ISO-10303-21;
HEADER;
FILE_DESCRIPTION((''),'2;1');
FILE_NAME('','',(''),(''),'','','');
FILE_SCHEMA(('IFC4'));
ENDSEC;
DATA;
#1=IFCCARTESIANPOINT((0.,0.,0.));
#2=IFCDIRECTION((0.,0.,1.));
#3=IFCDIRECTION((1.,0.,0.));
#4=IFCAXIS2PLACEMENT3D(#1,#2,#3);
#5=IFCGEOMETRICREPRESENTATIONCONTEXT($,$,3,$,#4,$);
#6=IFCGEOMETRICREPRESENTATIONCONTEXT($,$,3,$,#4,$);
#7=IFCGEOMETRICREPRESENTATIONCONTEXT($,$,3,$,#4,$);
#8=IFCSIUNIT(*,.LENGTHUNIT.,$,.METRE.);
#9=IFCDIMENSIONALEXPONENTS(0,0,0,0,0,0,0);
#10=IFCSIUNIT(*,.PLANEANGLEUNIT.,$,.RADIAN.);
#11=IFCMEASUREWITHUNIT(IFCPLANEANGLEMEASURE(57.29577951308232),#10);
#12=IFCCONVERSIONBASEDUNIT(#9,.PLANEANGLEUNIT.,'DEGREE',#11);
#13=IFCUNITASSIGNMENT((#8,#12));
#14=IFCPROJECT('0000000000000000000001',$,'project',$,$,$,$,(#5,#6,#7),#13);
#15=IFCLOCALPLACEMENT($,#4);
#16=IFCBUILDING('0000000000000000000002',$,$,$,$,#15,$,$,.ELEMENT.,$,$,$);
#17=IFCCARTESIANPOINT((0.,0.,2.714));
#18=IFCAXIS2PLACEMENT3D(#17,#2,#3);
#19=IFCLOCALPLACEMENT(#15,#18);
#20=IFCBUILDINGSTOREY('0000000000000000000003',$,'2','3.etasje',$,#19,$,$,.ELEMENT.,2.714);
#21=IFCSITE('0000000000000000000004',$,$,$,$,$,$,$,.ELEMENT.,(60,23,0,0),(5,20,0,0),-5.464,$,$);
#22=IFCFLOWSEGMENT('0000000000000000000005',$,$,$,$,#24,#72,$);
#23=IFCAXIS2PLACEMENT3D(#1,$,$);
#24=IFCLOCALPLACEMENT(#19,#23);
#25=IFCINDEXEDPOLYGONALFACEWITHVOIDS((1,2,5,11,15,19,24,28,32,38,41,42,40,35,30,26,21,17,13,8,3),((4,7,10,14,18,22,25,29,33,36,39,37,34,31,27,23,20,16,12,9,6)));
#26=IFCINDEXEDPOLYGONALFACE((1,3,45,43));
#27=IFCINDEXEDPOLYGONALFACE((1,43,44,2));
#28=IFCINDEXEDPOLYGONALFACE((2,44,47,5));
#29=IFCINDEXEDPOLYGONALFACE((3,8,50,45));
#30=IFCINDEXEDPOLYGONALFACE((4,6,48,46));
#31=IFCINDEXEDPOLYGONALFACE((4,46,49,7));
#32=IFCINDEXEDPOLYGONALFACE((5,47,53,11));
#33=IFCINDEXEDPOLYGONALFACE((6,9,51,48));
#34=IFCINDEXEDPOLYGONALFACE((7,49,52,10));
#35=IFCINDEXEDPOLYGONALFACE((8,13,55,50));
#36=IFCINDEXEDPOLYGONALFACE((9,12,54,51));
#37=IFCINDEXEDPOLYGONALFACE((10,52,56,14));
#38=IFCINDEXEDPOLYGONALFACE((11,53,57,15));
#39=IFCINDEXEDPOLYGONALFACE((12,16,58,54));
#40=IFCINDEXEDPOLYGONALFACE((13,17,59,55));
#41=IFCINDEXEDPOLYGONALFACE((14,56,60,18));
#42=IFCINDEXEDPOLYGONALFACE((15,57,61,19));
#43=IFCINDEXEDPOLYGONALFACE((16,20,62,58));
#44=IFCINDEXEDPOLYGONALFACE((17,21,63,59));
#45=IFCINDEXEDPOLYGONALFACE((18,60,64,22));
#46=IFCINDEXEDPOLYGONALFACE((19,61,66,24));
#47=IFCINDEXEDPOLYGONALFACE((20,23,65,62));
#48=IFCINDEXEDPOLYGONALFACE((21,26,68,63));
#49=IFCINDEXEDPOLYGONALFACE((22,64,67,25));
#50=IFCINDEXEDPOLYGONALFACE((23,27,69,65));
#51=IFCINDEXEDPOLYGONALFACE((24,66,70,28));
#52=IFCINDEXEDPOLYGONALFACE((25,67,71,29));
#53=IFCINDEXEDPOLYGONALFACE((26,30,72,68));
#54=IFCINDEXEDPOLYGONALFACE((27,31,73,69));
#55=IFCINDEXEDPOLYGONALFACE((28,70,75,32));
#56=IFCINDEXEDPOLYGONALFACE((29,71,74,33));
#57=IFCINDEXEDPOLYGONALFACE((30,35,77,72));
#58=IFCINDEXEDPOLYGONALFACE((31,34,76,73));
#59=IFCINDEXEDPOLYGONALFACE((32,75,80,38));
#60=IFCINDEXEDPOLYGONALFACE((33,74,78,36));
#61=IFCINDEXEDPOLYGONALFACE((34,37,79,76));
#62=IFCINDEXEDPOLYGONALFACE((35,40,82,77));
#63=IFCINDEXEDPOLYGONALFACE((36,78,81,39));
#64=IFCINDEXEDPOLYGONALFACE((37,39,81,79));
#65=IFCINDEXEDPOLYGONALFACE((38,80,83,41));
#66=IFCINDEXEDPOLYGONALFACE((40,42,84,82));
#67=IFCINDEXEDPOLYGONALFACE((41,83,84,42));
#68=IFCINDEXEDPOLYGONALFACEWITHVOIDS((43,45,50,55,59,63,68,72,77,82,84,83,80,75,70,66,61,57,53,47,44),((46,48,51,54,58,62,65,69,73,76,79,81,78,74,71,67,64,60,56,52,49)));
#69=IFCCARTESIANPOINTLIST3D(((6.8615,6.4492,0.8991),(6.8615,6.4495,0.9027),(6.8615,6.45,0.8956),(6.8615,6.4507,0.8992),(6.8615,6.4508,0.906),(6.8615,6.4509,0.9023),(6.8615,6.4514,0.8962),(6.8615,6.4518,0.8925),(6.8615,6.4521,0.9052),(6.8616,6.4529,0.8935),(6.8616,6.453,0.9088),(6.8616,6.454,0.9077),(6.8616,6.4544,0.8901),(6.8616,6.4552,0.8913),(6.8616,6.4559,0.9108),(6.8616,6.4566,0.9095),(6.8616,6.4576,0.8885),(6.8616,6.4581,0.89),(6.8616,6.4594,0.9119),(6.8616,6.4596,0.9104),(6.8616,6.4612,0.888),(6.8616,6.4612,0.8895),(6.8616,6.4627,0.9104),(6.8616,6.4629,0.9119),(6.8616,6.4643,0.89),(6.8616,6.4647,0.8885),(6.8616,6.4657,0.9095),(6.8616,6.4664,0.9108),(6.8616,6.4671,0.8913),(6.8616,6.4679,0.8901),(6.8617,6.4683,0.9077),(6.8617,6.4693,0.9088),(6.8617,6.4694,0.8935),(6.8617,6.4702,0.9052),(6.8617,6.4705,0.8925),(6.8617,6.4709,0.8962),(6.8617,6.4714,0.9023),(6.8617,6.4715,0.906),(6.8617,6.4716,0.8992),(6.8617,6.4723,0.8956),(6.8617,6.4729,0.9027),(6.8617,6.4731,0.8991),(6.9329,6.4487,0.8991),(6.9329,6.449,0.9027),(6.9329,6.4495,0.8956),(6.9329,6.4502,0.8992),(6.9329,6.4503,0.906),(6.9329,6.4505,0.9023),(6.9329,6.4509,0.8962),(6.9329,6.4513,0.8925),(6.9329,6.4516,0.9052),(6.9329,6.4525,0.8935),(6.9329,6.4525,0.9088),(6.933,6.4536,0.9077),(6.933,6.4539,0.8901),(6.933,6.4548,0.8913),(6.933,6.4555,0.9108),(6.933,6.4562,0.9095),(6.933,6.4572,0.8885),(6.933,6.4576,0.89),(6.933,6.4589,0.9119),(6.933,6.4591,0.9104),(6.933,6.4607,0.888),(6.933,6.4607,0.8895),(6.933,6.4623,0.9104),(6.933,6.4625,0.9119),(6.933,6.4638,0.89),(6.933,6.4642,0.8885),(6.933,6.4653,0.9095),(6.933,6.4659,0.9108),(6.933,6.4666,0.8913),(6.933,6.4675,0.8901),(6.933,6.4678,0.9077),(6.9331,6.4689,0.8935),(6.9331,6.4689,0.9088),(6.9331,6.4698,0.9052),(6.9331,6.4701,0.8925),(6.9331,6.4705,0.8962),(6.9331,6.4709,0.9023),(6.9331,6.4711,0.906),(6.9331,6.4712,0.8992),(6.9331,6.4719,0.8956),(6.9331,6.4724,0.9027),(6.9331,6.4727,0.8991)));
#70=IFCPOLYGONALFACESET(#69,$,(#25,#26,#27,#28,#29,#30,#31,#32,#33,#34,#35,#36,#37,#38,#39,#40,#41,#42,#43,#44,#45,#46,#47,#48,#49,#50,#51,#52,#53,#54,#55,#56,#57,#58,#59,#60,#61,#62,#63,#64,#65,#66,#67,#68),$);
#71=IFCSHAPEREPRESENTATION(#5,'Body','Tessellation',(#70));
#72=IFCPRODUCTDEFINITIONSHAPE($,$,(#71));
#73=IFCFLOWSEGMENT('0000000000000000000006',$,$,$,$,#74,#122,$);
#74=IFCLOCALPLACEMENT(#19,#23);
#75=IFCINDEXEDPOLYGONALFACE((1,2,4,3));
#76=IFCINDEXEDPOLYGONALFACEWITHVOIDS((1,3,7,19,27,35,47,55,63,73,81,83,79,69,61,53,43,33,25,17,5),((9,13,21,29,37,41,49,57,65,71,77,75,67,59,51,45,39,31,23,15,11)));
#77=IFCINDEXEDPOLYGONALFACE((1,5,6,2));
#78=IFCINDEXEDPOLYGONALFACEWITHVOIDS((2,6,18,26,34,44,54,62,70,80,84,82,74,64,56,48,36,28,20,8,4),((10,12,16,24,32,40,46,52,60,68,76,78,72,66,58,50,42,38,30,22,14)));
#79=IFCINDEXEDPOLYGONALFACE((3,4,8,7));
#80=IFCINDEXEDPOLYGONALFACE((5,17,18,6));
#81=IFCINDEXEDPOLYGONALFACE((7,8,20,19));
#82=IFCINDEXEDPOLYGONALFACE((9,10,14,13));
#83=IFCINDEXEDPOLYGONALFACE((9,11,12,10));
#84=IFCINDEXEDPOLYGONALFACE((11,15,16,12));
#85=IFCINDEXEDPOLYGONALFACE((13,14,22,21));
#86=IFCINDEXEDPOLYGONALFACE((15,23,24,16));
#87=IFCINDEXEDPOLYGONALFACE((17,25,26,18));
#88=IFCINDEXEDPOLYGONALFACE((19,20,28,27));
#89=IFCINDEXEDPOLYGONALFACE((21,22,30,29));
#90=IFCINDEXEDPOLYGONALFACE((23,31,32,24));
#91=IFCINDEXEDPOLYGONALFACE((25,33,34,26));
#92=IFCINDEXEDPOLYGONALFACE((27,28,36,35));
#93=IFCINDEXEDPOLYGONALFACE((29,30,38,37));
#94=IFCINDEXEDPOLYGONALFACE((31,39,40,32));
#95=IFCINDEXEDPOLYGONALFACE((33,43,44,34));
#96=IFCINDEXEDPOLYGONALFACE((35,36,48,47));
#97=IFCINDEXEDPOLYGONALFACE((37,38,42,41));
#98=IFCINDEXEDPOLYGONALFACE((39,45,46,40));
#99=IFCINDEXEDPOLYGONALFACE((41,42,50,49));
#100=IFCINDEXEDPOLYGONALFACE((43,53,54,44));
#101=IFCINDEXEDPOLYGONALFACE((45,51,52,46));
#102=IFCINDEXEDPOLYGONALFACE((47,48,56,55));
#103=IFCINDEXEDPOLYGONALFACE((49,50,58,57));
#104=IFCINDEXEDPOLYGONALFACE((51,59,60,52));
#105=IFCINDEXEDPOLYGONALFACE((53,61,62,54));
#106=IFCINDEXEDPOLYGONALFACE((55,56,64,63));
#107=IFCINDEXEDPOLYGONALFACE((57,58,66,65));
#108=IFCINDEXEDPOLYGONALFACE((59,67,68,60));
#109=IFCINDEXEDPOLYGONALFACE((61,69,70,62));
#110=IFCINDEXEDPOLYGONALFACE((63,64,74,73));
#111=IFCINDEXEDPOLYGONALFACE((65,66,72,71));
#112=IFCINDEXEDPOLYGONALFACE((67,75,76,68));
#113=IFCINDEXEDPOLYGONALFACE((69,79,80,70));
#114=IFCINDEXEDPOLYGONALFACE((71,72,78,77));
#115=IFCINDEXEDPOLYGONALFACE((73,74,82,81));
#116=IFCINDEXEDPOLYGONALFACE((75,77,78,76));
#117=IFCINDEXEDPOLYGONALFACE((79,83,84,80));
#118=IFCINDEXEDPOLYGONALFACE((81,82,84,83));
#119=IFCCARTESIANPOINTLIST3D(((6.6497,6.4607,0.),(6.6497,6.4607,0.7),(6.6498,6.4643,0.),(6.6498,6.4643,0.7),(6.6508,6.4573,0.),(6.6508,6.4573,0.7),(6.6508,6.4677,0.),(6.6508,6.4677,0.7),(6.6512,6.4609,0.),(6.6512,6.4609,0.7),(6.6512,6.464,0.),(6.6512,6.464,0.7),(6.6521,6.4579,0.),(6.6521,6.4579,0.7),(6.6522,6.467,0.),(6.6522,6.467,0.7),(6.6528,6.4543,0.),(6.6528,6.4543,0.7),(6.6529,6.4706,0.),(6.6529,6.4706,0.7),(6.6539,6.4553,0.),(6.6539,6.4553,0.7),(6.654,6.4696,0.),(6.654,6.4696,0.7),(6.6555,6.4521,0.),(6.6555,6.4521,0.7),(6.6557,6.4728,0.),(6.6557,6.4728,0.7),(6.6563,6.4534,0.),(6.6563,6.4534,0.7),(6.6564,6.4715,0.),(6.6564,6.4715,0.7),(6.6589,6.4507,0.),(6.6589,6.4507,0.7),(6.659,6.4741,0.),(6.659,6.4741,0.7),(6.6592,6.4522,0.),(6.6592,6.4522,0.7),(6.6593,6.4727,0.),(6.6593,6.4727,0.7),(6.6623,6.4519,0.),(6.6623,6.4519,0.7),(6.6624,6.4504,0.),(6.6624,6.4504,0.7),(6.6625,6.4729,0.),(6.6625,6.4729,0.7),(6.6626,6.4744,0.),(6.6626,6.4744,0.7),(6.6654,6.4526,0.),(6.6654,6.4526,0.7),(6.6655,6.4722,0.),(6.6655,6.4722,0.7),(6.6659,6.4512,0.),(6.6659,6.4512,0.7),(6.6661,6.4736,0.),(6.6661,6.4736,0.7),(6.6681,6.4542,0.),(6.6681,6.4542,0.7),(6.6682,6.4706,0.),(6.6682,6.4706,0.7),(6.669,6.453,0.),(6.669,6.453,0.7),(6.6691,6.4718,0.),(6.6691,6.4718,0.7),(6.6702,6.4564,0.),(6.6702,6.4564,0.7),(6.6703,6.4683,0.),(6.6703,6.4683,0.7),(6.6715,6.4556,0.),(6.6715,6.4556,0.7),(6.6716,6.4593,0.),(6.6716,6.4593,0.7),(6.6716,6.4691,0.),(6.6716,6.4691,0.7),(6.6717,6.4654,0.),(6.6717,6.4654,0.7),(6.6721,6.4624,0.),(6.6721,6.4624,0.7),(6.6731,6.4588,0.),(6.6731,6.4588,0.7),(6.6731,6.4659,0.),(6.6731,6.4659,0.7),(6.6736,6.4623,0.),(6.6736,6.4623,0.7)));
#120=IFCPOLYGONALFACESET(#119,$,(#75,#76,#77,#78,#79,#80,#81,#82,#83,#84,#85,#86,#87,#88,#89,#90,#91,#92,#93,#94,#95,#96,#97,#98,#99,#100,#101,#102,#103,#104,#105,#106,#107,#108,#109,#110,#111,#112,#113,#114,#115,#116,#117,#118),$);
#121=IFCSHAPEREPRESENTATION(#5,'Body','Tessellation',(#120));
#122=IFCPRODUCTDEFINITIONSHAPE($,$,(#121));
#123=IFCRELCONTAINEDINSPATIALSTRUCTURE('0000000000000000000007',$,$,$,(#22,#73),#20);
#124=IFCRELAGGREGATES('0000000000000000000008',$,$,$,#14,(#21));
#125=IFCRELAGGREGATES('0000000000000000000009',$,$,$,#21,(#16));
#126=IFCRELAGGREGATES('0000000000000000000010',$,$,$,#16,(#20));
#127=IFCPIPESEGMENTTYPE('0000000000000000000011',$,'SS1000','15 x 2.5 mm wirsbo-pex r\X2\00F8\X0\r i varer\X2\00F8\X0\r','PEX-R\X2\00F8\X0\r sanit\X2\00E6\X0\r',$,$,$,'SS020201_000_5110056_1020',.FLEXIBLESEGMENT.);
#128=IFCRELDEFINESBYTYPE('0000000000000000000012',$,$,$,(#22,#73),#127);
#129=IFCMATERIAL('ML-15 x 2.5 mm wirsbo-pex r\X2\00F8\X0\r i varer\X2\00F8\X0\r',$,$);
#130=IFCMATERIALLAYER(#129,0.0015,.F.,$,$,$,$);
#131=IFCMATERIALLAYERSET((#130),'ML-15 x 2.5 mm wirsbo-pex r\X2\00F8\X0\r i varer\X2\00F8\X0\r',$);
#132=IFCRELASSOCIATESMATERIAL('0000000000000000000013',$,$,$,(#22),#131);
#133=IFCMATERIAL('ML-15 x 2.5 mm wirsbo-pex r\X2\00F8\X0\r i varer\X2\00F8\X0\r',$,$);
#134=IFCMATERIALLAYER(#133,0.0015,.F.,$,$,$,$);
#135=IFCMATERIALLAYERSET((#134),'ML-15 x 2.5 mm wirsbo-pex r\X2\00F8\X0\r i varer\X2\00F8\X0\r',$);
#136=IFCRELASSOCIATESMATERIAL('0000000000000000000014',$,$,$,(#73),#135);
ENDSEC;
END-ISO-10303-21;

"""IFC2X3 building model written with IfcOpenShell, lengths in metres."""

from ifc_helpers import new_model, entity, si_unit, converted_unit, frame, origin_with_axes, origin_2d_with_axis, place, context, project, spatial, hollow_circle, extrude, material, layer, layer_set, layer_usage, type_object, element, save


model = new_model("IFC2X3")

# Units and contexts
context_of_model_1 = context(None, 3, world=origin_with_axes())
context_of_model_2 = context(None, 3, world=origin_with_axes())
context_of_model_3 = context(None, 3, world=origin_with_axes())
ifc_project = project(units=[si_unit("LENGTHUNIT", "METRE"), converted_unit("PLANEANGLEUNIT", "DEGREE", entity("IfcPlaneAngleMeasure", 57.29577951308232), si_unit("PLANEANGLEUNIT", "RADIAN"), dimensions=[0, 0, 0, 0, 0, 0, 0])], contexts=[context_of_model_1, context_of_model_2, context_of_model_3])

# Site, building, storey
site = spatial("IfcSite", under=ifc_project, CompositionType="ELEMENT", RefLatitude=(60, 23, 0, 0), RefLongitude=(5, 20, 0, 0), RefElevation=-5.464)
building_placement = place(None, origin_with_axes())
building = spatial("IfcBuilding", under=site, at=building_placement, CompositionType="ELEMENT")
storey_placement = place(building_placement, frame((0.0, 0.0, 2.714), z_axis=(0.0, 0.0, 1.0), x_axis=(1.0, 0.0, 0.0)))
storey = spatial("IfcBuildingStorey", under=building, at=storey_placement, Name="2", Description="3.etasje", CompositionType="ELEMENT", Elevation=2.714)

# Flow segments
ifc_material_1 = material(Name="ML-15 x 2.5 mm wirsbo-pex rør i varerør")
ifc_layer_1 = layer(ifc_material_1, 0.0015, ventilated=False)
ifc_layer_set_1 = layer_set([ifc_layer_1], Name="ML-15 x 2.5 mm wirsbo-pex rør i varerør")
ifc_layer_usage_1 = layer_usage(ifc_layer_set_1, "AXIS2", "POSITIVE", 0.0)
pipe_segment_type_1 = type_object("IfcPipeSegmentType", Name="SS1000", Description="15 x 2.5 mm wirsbo-pex rør i varerør", ApplicableOccurrence="PEX-Rør sanitær", ElementType="SS020201_000_5110056_1020", PredefinedType="FLEXIBLESEGMENT")
flow_segment_1_placement = place(storey_placement, frame((6.933, 6.4607, 0.9), z_axis=(-0.99998, 0.006302, 0.0), x_axis=(0.0, 0.0, -1.0)))
element("IfcFlowSegment", 1, at=flow_segment_1_placement, inside=storey, type_object=pipe_segment_type_1, material=ifc_layer_usage_1, context=context_of_model_1, shape_type="SweptSolid", body=[
    extrude(hollow_circle(Radius=0.012, WallThickness=0.0015, at=origin_2d_with_axis()), origin_with_axes(), (0.0, 0.0, 1.0), 0.0714),
])
ifc_material_2 = material(Name="ML-15 x 2.5 mm wirsbo-pex rør i varerør")
ifc_layer_2 = layer(ifc_material_2, 0.0015, ventilated=False)
ifc_layer_set_2 = layer_set([ifc_layer_2], Name="ML-15 x 2.5 mm wirsbo-pex rør i varerør")
ifc_layer_usage_2 = layer_usage(ifc_layer_set_2, "AXIS2", "POSITIVE", 0.0)
flow_segment_2_placement = place(storey_placement, frame((6.6616, 6.4624, 0.7), z_axis=(0.0, 0.0, -1.0), x_axis=(0.99998, -0.006302, 0.0)))
element("IfcFlowSegment", 2, at=flow_segment_2_placement, inside=storey, type_object=pipe_segment_type_1, material=ifc_layer_usage_2, context=context_of_model_1, shape_type="SweptSolid", body=[
    extrude(hollow_circle(Radius=0.012, WallThickness=0.0015, at=origin_2d_with_axis()), origin_with_axes(), (0.0, 0.0, 1.0), 0.7),
])

save(model, "model.ifc")
